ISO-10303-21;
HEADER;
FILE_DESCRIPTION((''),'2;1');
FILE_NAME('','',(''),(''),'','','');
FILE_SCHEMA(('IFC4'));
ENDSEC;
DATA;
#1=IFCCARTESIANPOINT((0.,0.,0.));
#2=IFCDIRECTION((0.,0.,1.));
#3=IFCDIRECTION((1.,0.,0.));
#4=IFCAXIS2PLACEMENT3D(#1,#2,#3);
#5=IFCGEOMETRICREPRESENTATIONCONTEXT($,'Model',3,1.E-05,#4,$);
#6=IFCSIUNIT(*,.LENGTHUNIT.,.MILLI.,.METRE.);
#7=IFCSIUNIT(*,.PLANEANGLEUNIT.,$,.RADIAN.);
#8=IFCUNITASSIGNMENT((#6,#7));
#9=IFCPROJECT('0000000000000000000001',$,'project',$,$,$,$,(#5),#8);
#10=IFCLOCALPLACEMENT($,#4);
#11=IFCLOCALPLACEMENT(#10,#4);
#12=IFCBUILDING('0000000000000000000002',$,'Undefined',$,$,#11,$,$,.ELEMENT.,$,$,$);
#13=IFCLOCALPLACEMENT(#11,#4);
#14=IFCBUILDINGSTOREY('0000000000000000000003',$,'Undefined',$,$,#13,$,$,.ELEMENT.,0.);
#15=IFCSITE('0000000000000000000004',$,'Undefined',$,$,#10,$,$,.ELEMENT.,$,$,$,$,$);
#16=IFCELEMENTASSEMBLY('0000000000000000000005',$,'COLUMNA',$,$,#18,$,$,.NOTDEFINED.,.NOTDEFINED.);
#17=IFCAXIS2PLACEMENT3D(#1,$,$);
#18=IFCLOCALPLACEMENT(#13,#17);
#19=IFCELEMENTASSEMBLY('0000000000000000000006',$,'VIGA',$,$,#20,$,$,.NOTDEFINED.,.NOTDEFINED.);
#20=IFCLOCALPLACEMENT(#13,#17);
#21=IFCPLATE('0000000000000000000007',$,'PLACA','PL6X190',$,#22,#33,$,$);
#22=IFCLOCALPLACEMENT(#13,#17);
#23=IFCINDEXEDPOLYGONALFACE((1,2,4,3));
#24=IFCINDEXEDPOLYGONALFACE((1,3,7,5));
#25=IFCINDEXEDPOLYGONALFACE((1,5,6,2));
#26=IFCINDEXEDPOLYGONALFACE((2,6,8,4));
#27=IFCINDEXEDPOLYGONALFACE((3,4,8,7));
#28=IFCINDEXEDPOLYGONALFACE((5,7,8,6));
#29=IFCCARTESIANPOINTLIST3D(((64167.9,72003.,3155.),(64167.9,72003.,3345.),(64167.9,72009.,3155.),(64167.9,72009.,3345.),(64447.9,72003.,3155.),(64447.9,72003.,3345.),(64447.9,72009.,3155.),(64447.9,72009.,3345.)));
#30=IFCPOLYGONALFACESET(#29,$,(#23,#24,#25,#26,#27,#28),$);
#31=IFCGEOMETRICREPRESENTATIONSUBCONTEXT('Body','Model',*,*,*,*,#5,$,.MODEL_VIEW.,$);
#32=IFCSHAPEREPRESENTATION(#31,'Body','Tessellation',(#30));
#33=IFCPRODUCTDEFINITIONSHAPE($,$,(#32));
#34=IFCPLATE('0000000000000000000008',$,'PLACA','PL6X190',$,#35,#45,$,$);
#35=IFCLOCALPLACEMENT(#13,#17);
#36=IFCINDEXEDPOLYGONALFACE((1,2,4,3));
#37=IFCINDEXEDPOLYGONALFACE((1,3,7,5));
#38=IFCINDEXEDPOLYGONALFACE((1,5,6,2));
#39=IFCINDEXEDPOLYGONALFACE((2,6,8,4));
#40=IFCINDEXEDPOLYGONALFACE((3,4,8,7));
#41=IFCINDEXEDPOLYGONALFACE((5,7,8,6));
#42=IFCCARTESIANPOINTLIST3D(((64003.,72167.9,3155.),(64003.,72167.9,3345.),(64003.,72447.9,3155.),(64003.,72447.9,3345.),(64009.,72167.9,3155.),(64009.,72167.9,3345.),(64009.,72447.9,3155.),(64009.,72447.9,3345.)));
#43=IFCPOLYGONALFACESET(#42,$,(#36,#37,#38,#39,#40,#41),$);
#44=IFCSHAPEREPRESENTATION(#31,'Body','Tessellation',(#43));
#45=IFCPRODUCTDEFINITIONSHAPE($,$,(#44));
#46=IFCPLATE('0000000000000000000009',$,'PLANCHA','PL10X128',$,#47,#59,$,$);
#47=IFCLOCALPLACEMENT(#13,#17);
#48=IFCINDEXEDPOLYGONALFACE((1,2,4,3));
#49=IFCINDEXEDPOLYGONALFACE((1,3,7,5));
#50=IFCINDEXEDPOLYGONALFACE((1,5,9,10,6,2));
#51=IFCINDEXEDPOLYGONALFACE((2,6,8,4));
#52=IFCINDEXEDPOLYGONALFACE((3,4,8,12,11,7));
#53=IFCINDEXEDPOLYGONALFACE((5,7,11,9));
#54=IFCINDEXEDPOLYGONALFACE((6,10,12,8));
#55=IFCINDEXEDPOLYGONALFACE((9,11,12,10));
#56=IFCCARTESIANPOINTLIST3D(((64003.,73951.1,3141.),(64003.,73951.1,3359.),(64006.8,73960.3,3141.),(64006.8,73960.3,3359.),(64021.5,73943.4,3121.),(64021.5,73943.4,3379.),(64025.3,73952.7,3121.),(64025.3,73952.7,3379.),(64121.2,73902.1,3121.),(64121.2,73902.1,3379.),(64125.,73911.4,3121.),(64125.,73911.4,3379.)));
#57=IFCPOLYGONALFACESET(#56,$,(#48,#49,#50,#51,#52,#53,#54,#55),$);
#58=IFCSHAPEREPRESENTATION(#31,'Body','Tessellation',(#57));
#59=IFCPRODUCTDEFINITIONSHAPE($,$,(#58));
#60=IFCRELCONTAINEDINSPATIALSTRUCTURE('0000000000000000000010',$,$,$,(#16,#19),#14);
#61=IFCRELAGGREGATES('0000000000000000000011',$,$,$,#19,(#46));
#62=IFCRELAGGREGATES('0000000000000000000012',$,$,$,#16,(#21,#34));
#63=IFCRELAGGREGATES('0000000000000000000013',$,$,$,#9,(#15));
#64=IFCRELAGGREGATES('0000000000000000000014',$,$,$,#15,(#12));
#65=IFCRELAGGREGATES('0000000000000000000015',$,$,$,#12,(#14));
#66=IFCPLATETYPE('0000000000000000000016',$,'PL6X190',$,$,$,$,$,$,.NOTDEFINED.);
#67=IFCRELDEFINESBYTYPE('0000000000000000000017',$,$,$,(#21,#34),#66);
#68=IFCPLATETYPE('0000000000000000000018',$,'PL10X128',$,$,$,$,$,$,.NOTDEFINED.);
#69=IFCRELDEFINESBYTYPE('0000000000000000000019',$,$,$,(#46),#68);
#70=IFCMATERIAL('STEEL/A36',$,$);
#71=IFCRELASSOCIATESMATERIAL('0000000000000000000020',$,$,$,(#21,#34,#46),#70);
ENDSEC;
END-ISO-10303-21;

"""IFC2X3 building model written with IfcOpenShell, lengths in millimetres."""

from ifc_helpers import new_model, si_unit, frame, origin_with_axes, place, context, subcontext, project, spatial, polyline, outline, extrude, material, type_object, element, aggregate, save


model = new_model("IFC2X3")

# Units and contexts
model_context = context("Model", 3, precision=1e-05, world=origin_with_axes())
body_context = subcontext(model_context, "Body", "Model", "MODEL_VIEW")
ifc_project = project(units=[si_unit("LENGTHUNIT", "METRE", prefix="MILLI"), si_unit("PLANEANGLEUNIT", "RADIAN")], contexts=[model_context])

# Site, building, storey
site_placement = place(None, origin_with_axes())
site = spatial("IfcSite", under=ifc_project, at=site_placement, Name="Undefined", CompositionType="ELEMENT")
building_placement = place(site_placement, origin_with_axes())
building = spatial("IfcBuilding", under=site, at=building_placement, Name="Undefined", CompositionType="ELEMENT")
storey_placement = place(building_placement, origin_with_axes())
storey = spatial("IfcBuildingStorey", under=building, at=storey_placement, Name="Undefined", CompositionType="ELEMENT", Elevation=0.0)

# Element assembly
assembly_1_placement = place(storey_placement, origin_with_axes())
assembly_1 = element("IfcElementAssembly", 1, at=assembly_1_placement, inside=storey, Name="COLUMNA", AssemblyPlace="NOTDEFINED", PredefinedType="NOTDEFINED")
ifc_material_1 = material(Name="STEEL/A36")

# Element assembly
assembly_2_placement = place(storey_placement, origin_with_axes())
assembly_2 = element("IfcElementAssembly", 2, at=assembly_2_placement, inside=storey, Name="VIGA", AssemblyPlace="NOTDEFINED", PredefinedType="NOTDEFINED")

# Plates
plate_type_1 = type_object("IfcPlateType", Name="PL6X190", PredefinedType="NOTDEFINED")
plate_1_placement = place(assembly_1_placement, frame((64447.9, 72006.0, 3250.0), z_axis=(0.0, 1.0, 0.0), x_axis=(-1.0, 0.0, 0.0)))
plate_1 = element("IfcPlate", 3, at=plate_1_placement, type_object=plate_type_1, material=ifc_material_1, Name="PLACA", Description="PL6X190", context=body_context, shape_type="SweptSolid", body=[
    extrude(outline(polyline([(0.0, -95.0), (0.0, 95.0), (280.0, 95.0), (280.0, -95.0), (0.0, -95.0)])), frame((0.0, 0.0, -3.0), z_axis=(0.0, 0.0, 1.0), x_axis=(1.0, 0.0, 0.0)), (0.0, 0.0, 1.0), 6.0),
])
plate_2_placement = place(assembly_1_placement, frame((64006.0, 72447.9, 3250.0), z_axis=(-1.0, 0.0, 0.0), x_axis=(0.0, -1.0, 0.0)))
plate_2 = element("IfcPlate", 4, at=plate_2_placement, type_object=plate_type_1, material=ifc_material_1, Name="PLACA", Description="PL6X190", context=body_context, shape_type="SweptSolid", body=[
    extrude(outline(polyline([(0.0, -95.0), (0.0, 95.0), (280.0, 95.0), (280.0, -95.0), (0.0, -95.0)])), frame((0.0, 0.0, -3.0), z_axis=(0.0, 0.0, 1.0), x_axis=(1.0, 0.0, 0.0)), (0.0, 0.0, 1.0), 6.0),
])
plate_type_2 = type_object("IfcPlateType", Name="PL10X128", PredefinedType="NOTDEFINED")
plate_3_placement = place(assembly_2_placement, frame((64004.9, 73955.7, 3121.0), z_axis=(-0.382684, -0.923879, 0.0), x_axis=(0.923879, -0.382684, 0.0)))
plate_3 = element("IfcPlate", 5, at=plate_3_placement, type_object=plate_type_2, material=ifc_material_1, Name="PLANCHA", Description="PL10X128", context=body_context, shape_type="SweptSolid", body=[
    extrude(outline(polyline([(0.0, 20.0), (20.0, 0.0), (127.9, 0.0), (127.9, 258.0), (20.0, 258.0), (0.0, 238.0), (0.0, 20.0)])), frame((0.0, 0.0, -5.0), z_axis=(0.0, 0.0, 1.0), x_axis=(1.0, 0.0, 0.0)), (0.0, 0.0, 1.0), 10.0),
])
aggregate(assembly_2, [plate_3])

aggregate(assembly_1, [plate_1, plate_2])

save(model, "model.ifc")
